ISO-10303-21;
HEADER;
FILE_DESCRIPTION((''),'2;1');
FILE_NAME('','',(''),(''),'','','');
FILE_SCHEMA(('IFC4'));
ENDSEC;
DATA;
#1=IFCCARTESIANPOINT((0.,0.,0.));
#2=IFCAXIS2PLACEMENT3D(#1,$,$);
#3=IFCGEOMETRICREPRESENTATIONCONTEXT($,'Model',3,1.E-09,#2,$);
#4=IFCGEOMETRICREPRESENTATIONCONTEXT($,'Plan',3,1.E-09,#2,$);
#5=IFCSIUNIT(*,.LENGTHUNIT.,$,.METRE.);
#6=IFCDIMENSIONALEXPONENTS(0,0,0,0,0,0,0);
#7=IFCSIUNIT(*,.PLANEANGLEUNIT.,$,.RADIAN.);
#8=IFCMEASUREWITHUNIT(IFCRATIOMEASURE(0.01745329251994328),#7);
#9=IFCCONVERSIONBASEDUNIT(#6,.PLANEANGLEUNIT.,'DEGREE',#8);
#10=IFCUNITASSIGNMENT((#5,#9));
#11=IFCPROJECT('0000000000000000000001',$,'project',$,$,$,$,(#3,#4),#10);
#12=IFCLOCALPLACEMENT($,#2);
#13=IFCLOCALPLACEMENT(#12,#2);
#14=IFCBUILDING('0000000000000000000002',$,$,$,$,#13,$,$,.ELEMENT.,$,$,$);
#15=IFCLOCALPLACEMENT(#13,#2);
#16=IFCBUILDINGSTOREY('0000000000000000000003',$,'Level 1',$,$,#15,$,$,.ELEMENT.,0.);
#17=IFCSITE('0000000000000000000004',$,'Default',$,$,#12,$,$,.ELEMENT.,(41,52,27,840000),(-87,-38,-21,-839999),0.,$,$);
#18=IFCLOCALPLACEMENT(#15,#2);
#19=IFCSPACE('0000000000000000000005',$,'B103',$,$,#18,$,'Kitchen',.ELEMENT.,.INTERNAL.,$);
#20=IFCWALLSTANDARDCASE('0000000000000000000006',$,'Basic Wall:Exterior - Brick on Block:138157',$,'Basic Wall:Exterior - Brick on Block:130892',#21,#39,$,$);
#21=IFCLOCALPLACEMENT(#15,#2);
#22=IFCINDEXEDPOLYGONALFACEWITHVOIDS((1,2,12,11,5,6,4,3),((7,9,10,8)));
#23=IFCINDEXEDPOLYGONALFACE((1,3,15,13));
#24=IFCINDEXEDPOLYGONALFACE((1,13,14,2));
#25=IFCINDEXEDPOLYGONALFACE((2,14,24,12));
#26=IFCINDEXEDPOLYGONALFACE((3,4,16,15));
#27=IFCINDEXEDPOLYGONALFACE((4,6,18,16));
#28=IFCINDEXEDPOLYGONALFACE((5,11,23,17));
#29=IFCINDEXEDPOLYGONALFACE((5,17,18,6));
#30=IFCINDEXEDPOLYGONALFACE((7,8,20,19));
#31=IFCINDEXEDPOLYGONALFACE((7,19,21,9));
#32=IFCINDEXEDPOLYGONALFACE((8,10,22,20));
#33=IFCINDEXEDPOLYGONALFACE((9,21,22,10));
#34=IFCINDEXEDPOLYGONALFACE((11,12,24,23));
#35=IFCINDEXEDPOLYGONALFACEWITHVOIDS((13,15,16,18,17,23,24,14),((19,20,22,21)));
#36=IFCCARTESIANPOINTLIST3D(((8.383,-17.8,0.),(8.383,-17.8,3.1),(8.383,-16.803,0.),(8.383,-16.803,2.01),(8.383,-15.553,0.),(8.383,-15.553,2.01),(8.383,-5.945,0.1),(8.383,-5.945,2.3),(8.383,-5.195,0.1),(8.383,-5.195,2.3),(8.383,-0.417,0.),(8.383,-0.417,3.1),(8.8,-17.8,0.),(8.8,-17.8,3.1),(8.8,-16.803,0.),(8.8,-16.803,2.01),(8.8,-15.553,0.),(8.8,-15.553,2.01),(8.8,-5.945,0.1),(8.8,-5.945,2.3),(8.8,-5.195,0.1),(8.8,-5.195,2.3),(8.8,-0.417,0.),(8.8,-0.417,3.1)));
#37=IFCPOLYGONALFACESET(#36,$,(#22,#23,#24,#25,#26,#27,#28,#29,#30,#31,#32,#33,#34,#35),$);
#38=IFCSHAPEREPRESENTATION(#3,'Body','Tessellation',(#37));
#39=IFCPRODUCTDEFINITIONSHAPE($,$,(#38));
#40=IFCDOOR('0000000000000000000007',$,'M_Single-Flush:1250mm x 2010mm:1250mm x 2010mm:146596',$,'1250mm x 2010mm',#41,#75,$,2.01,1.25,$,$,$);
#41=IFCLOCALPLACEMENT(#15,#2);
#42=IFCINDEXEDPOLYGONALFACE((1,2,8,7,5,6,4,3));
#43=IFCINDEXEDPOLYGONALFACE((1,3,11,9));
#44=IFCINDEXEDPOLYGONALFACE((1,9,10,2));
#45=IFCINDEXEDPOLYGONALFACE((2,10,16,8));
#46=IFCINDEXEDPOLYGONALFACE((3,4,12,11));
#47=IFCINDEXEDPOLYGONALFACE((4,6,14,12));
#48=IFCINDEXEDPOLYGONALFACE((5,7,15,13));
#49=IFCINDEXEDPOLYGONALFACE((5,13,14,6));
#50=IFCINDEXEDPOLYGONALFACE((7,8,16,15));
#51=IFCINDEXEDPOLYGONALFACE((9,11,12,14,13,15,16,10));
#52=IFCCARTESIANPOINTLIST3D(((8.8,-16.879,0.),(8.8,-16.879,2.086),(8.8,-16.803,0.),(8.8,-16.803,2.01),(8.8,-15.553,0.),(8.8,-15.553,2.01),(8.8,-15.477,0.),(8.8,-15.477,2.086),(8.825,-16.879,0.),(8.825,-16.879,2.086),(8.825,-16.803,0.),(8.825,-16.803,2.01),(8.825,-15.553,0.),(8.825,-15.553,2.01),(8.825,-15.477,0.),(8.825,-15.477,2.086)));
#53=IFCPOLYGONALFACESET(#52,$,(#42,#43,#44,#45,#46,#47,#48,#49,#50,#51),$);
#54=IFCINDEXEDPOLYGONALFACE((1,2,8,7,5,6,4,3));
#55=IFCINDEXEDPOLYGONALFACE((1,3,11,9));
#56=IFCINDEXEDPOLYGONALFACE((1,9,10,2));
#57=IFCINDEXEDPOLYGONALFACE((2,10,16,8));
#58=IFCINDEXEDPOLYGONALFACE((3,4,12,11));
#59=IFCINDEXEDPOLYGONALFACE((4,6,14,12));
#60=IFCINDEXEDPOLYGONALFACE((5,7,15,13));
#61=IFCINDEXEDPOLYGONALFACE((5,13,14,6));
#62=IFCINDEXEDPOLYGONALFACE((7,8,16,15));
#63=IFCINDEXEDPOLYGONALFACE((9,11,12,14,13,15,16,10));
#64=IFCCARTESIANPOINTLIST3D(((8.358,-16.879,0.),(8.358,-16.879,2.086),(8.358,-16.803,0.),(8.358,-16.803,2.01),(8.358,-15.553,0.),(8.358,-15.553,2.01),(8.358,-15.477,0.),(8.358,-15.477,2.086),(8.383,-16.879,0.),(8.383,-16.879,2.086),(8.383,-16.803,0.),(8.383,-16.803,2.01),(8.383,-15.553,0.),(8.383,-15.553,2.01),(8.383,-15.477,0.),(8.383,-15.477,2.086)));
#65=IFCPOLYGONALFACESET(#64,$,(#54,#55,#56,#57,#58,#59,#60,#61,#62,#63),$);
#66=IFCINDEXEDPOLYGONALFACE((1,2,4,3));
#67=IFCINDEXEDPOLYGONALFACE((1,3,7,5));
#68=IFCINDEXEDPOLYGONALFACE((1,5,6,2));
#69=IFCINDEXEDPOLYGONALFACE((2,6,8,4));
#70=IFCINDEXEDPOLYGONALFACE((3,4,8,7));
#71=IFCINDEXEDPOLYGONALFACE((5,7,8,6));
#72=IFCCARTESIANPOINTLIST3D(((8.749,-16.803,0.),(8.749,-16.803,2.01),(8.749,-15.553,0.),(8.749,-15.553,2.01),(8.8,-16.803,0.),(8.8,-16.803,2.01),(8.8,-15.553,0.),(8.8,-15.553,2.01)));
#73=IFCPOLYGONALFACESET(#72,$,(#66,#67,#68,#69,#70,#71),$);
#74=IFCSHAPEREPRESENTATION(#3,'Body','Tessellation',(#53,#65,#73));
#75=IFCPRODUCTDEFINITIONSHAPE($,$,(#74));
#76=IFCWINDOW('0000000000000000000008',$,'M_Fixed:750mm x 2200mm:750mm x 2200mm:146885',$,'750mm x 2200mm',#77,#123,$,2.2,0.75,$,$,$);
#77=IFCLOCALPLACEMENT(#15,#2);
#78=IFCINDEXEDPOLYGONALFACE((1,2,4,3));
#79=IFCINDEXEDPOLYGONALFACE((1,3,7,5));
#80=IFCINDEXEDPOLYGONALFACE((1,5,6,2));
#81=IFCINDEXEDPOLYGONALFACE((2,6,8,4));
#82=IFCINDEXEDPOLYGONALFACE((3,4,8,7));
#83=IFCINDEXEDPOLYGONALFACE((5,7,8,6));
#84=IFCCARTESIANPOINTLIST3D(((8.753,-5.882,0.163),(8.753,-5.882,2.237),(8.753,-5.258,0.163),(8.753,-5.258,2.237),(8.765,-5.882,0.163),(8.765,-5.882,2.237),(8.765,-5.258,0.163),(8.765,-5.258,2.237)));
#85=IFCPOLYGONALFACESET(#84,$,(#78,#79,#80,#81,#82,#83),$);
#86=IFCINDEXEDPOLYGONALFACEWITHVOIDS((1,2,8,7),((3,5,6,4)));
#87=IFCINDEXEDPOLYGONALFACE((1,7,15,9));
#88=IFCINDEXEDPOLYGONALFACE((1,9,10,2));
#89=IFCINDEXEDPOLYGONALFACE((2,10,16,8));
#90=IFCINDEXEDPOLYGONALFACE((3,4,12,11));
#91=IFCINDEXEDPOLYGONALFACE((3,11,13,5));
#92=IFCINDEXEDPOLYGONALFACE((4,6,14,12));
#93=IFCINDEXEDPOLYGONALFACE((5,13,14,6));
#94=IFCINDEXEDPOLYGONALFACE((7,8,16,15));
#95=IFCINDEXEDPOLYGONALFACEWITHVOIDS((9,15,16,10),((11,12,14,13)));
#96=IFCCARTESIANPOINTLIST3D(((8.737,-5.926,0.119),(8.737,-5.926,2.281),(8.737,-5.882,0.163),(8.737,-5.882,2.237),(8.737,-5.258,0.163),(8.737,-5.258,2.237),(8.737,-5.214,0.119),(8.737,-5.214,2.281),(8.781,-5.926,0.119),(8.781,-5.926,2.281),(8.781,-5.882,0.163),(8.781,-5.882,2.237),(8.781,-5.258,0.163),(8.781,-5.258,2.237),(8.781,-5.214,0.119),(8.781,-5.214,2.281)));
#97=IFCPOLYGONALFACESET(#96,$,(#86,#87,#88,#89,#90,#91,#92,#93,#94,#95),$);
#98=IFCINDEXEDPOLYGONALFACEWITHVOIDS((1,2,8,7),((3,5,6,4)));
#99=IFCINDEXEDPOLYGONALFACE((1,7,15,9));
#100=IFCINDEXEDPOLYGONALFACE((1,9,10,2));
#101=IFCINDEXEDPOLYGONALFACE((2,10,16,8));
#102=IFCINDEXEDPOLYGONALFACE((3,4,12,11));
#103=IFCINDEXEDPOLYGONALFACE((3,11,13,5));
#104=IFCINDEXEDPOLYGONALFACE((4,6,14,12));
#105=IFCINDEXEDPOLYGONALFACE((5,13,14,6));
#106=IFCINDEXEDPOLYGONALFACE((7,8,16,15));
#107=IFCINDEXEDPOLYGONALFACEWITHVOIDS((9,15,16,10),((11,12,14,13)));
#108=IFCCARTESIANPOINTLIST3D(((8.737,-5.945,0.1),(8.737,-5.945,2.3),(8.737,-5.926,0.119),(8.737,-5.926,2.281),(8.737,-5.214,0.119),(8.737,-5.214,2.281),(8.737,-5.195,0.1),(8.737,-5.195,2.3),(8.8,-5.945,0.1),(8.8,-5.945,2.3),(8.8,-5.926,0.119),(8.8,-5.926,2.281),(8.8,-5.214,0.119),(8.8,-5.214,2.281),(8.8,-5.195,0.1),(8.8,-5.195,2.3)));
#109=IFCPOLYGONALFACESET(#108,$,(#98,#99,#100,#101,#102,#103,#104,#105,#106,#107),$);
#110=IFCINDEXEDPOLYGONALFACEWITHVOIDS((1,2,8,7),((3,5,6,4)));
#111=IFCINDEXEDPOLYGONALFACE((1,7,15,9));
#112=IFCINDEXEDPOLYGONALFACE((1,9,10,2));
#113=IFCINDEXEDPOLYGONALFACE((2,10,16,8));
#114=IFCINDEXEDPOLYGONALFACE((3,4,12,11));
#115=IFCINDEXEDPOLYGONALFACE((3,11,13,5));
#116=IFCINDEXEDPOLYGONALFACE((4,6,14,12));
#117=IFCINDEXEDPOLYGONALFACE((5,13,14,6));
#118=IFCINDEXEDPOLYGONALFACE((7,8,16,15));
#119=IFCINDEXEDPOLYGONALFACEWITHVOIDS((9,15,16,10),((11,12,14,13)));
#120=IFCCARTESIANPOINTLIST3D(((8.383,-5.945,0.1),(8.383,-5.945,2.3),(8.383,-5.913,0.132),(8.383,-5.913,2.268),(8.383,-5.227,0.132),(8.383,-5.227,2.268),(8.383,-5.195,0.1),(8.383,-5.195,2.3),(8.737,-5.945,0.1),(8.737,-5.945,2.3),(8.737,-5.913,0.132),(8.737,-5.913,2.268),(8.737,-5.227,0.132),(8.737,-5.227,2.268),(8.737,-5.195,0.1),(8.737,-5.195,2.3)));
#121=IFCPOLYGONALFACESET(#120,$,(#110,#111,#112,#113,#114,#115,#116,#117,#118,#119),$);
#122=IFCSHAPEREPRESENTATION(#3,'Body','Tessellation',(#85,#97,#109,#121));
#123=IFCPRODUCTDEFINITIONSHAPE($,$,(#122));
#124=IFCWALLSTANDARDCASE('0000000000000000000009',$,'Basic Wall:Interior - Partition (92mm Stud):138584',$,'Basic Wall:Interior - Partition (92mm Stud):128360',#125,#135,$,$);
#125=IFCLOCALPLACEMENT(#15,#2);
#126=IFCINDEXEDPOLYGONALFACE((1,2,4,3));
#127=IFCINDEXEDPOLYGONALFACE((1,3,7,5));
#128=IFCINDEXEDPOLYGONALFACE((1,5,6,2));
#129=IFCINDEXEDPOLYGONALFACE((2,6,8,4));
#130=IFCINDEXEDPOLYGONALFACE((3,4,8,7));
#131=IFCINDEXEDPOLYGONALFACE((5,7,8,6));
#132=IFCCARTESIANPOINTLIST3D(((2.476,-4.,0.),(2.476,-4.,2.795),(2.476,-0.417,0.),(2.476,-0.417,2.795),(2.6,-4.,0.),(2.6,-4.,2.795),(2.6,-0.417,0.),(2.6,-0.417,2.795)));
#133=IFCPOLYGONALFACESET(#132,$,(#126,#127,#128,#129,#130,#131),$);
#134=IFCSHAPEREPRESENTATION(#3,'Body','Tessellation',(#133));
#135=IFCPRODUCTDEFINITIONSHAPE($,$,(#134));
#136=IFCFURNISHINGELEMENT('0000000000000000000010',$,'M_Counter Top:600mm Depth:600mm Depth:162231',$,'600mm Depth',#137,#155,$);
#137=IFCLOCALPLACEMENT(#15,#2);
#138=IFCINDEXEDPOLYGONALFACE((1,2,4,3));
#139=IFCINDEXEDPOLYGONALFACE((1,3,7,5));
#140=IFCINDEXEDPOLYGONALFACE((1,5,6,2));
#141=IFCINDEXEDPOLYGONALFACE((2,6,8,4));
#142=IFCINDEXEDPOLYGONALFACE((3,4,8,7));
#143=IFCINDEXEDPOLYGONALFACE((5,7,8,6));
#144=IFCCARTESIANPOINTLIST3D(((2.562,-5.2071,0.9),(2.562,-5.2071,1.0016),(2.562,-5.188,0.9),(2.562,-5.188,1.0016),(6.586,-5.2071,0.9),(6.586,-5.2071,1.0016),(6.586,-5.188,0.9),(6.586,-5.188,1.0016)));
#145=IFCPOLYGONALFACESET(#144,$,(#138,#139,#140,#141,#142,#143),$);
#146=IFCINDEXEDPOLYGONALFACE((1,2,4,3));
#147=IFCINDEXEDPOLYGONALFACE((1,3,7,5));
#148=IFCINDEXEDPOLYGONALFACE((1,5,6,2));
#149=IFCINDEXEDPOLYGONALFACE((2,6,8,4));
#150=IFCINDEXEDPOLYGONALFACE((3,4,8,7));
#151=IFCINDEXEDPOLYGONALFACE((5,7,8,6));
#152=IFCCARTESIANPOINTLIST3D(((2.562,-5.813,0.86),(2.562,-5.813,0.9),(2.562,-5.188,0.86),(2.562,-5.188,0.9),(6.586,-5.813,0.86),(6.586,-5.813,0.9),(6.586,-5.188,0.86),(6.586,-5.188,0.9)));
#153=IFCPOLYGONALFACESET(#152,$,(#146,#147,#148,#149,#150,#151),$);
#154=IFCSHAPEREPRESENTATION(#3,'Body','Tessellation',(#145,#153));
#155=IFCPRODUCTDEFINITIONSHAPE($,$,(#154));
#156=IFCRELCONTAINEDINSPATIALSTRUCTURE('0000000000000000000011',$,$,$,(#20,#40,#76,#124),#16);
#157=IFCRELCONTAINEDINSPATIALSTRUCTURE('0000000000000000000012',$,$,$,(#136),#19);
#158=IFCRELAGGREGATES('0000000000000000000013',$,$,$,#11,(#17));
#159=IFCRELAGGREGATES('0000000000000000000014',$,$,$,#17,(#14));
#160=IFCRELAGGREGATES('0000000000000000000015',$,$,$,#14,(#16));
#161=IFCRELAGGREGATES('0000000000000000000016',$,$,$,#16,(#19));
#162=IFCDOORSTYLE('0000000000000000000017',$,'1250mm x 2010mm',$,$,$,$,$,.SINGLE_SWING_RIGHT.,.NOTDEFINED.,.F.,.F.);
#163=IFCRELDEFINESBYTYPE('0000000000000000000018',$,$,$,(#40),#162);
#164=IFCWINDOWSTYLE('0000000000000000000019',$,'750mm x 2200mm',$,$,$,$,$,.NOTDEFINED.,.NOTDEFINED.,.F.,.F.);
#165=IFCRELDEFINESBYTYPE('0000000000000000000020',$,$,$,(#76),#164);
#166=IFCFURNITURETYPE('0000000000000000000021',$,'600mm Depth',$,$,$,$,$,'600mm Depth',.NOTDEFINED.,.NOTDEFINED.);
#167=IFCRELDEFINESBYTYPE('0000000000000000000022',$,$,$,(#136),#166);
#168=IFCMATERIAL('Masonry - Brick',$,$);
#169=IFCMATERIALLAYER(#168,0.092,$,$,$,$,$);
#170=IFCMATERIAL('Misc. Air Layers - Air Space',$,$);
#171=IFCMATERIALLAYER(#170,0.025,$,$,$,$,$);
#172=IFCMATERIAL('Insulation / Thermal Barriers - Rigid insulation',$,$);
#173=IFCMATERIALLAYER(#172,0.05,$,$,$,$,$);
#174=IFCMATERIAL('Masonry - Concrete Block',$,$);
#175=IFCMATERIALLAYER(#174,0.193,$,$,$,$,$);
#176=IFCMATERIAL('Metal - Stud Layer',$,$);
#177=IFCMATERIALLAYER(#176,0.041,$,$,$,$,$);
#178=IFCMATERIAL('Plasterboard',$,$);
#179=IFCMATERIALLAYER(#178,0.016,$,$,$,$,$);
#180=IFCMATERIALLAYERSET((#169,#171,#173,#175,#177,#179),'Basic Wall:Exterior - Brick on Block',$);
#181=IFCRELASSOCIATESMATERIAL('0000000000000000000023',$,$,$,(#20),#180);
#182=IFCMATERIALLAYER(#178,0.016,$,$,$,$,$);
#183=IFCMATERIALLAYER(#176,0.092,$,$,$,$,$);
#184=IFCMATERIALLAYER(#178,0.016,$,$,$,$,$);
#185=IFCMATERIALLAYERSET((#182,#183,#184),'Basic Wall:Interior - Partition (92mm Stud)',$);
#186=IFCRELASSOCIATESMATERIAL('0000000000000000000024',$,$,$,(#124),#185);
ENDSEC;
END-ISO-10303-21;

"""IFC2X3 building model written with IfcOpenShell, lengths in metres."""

from ifc_helpers import new_model, entity, si_unit, converted_unit, frame, frame_2d, origin, origin_2d_with_axis, place, context, project, spatial, polyline, rectangle, outline, extrude, source, transform, mapped, material, layer, layer_set, layer_usage, type_object, type_shapes, element, fill, save


model = new_model("IFC2X3")

# Units and contexts
model_context = context("Model", 3, precision=1e-09, world=origin())
plan_context = context("Plan", 3, precision=1e-09, world=origin())
ifc_project = project(units=[si_unit("LENGTHUNIT", "METRE"), converted_unit("PLANEANGLEUNIT", "DEGREE", entity("IfcRatioMeasure", 0.01745329251994328), si_unit("PLANEANGLEUNIT", "RADIAN"), dimensions=[0, 0, 0, 0, 0, 0, 0])], contexts=[model_context, plan_context])

# Site, building, storey
site_placement = place(None, origin())
site = spatial("IfcSite", under=ifc_project, at=site_placement, Name="Default", CompositionType="ELEMENT", RefLatitude=(41, 52, 27, 840000), RefLongitude=(-87, -38, -21, -839999), RefElevation=0.0)
building_placement = place(site_placement, origin())
building = spatial("IfcBuilding", under=site, at=building_placement, CompositionType="ELEMENT")
storey_placement = place(building_placement, origin())
storey = spatial("IfcBuildingStorey", under=building, at=storey_placement, Name="Level 1", CompositionType="ELEMENT", Elevation=0.0)

# Wall, openings, door, window
ifc_material_1 = material(Name="Masonry - Brick")
ifc_layer_1 = layer(ifc_material_1, 0.092)
ifc_material_2 = material(Name="Misc. Air Layers - Air Space")
ifc_layer_2 = layer(ifc_material_2, 0.025)
ifc_material_3 = material(Name="Insulation / Thermal Barriers - Rigid insulation")
ifc_layer_3 = layer(ifc_material_3, 0.05)
ifc_material_4 = material(Name="Masonry - Concrete Block")
ifc_layer_4 = layer(ifc_material_4, 0.193)
ifc_material_5 = material(Name="Metal - Stud Layer")
ifc_layer_5 = layer(ifc_material_5, 0.041)
ifc_material_6 = material(Name="Plasterboard")
ifc_layer_6 = layer(ifc_material_6, 0.016)
ifc_layer_set_1 = layer_set([ifc_layer_1, ifc_layer_2, ifc_layer_3, ifc_layer_4, ifc_layer_5, ifc_layer_6], Name="Basic Wall:Exterior - Brick on Block")
ifc_layer_usage_1 = layer_usage(ifc_layer_set_1, "AXIS2", "NEGATIVE", 0.2085)
wall_1_placement = place(storey_placement, frame((8.5915, -0.417, 0.0), z_axis=(0.0, 0.0, 1.0), x_axis=(0.0, -1.0, 0.0)))
wall_1 = element("IfcWallStandardCase", 1, at=wall_1_placement, inside=storey, material=ifc_layer_usage_1, Name="Basic Wall:Exterior - Brick on Block:138157", ObjectType="Basic Wall:Exterior - Brick on Block:130892", context=model_context, shape_type="SweptSolid", body=[
    extrude(rectangle(XDim=17.383, YDim=0.417, at=frame_2d((8.6915, 0.0), x_axis=(-1.0, 0.0))), origin(), (0.0, 0.0, 1.0), 3.1),
])
opening_1_placement = place(wall_1_placement, frame((15.136, -0.2085, 0.0)))
opening_1 = element("IfcOpeningElement", 2, at=opening_1_placement, cuts=wall_1, ObjectType="Opening", context=model_context, shape_type="SweptSolid", body=[
    extrude(rectangle(XDim=1.25, YDim=2.01, at=frame_2d((1.005, 0.625), x_axis=(0.0, 1.0))), frame((0.0, 0.0, 0.0), z_axis=(0.0, 1.0, 0.0), x_axis=(0.0, 0.0, 1.0)), (0.0, 0.0, 1.0), 0.417),
])
opening_2_placement = place(wall_1_placement, frame((4.778, -0.2085, 0.1)))
opening_2 = element("IfcOpeningElement", 3, at=opening_2_placement, cuts=wall_1, ObjectType="Opening", context=model_context, shape_type="SweptSolid", body=[
    extrude(rectangle(XDim=2.2, YDim=0.75, at=frame_2d((1.1, 0.375), x_axis=(1.0, 0.0))), frame((0.0, 0.0, 0.0), z_axis=(0.0, 1.0, 0.0), x_axis=(0.0, 0.0, 1.0)), (0.0, 0.0, 1.0), 0.417),
])
door_style = type_object("IfcDoorStyle", Name="1250mm x 2010mm", ConstructionType="NOTDEFINED", OperationType="SINGLE_SWING_RIGHT", ParameterTakesPrecedence=False, Sizeable=False)
shared_shape_1 = source(origin(), model_context, "Body", "SweptSolid", [
    extrude(outline(polyline([(-0.701, -1.062), (0.701, -1.062), (0.701, 1.024), (0.625, 1.024), (0.625, -0.986), (-0.625, -0.986), (-0.625, 1.024), (-0.701, 1.024), (-0.701, -1.062)])), frame((0.625, 0.417, 1.024), z_axis=(0.0, 1.0, 0.0), x_axis=(1.0, 0.0, 0.0)), (0.0, 0.0, 1.0), 0.025),
    extrude(outline(polyline([(-1.062, -0.701), (1.024, -0.701), (1.024, -0.625), (-0.986, -0.625), (-0.986, 0.625), (1.024, 0.625), (1.024, 0.701), (-1.062, 0.701), (-1.062, -0.701)])), frame((0.625, -0.025, 1.024), z_axis=(0.0, 1.0, 0.0), x_axis=(0.0, 0.0, -1.0)), (0.0, 0.0, 1.0), 0.025),
    extrude(rectangle(XDim=0.051, YDim=1.25, at=origin_2d_with_axis()), frame((0.625, 0.3915, 0.0), z_axis=(0.0, 0.0, 1.0), x_axis=(0.0, 1.0, 0.0)), (0.0, 0.0, 1.0), 2.01),
])
type_shapes(door_style, [shared_shape_1])
door_placement = place(opening_1_placement, origin())
door = element("IfcDoor", 4, at=door_placement, inside=storey, type_object=door_style, Name="M_Single-Flush:1250mm x 2010mm:1250mm x 2010mm:146596", ObjectType="1250mm x 2010mm", OverallHeight=2.01, OverallWidth=1.25, context=model_context, shape_type="MappedRepresentation", body=[
    mapped(shared_shape_1, transform((0.0, 0.0, 0.0), scale=1.0)),
])
fill(opening_1, door)
window_style = type_object("IfcWindowStyle", Name="750mm x 2200mm", ConstructionType="NOTDEFINED", OperationType="NOTDEFINED", ParameterTakesPrecedence=False, Sizeable=False)
shared_shape_2 = source(origin(), model_context, "Body", "SweptSolid", [
    extrude(rectangle(XDim=0.012, YDim=0.624, at=origin_2d_with_axis()), frame((0.375, 0.376, 0.063), z_axis=(0.0, 0.0, 1.0), x_axis=(0.0, -1.0, 0.0)), (0.0, 0.0, 1.0), 2.074),
    extrude(outline(polyline([(-0.356, -1.081), (0.356, -1.081), (0.356, 1.081), (-0.356, 1.081), (-0.356, -1.081)]), holes=[polyline([(-0.312, -1.037), (-0.312, 1.037), (0.312, 1.037), (0.312, -1.037), (-0.312, -1.037)])]), frame((0.375, 0.354, 1.1), z_axis=(0.0, 1.0, 0.0), x_axis=(1.0, 0.0, 0.0)), (0.0, 0.0, 1.0), 0.044),
    extrude(outline(polyline([(-0.375, -1.1), (0.375, -1.1), (0.375, 1.1), (-0.375, 1.1), (-0.375, -1.1)]), holes=[polyline([(-0.356, -1.081), (-0.356, 1.081), (0.356, 1.081), (0.356, -1.081), (-0.356, -1.081)])]), frame((0.375, 0.354, 1.1), z_axis=(0.0, 1.0, 0.0), x_axis=(1.0, 0.0, 0.0)), (0.0, 0.0, 1.0), 0.063),
    extrude(outline(polyline([(-0.375, -1.1), (0.375, -1.1), (0.375, 1.1), (-0.375, 1.1), (-0.375, -1.1)]), holes=[polyline([(-0.343, -1.068), (-0.343, 1.068), (0.343, 1.068), (0.343, -1.068), (-0.343, -1.068)])]), frame((0.375, 0.0, 1.1), z_axis=(0.0, 1.0, 0.0), x_axis=(1.0, 0.0, 0.0)), (0.0, 0.0, 1.0), 0.354),
])
type_shapes(window_style, [shared_shape_2])
window_placement = place(opening_2_placement, origin())
window = element("IfcWindow", 5, at=window_placement, inside=storey, type_object=window_style, Name="M_Fixed:750mm x 2200mm:750mm x 2200mm:146885", ObjectType="750mm x 2200mm", OverallHeight=2.2, OverallWidth=0.75, context=model_context, shape_type="MappedRepresentation", body=[
    mapped(shared_shape_2, transform((0.0, 0.0, 0.0), scale=1.0)),
])
fill(opening_2, window)

# Wall
ifc_layer_7 = layer(ifc_material_6, 0.016)
ifc_layer_8 = layer(ifc_material_5, 0.092)
ifc_layer_9 = layer(ifc_material_6, 0.016)
ifc_layer_set_2 = layer_set([ifc_layer_7, ifc_layer_8, ifc_layer_9], Name="Basic Wall:Interior - Partition (92mm Stud)")
ifc_layer_usage_2 = layer_usage(ifc_layer_set_2, "AXIS2", "NEGATIVE", 0.062)
wall_2_placement = place(storey_placement, frame((2.538, -0.417, 0.0), z_axis=(0.0, 0.0, 1.0), x_axis=(0.0, -1.0, 0.0)))
element("IfcWallStandardCase", 6, at=wall_2_placement, inside=storey, material=ifc_layer_usage_2, Name="Basic Wall:Interior - Partition (92mm Stud):138584", ObjectType="Basic Wall:Interior - Partition (92mm Stud):128360", context=model_context, shape_type="SweptSolid", body=[
    extrude(rectangle(XDim=3.583, YDim=0.124, at=frame_2d((1.7915, 0.0), x_axis=(-1.0, 0.0))), origin(), (0.0, 0.0, 1.0), 2.795),
])

# Shared definitions
space_1_placement = place(storey_placement, origin())
space_1 = spatial("IfcSpace", under=storey, at=space_1_placement, Name="B103", LongName="Kitchen", CompositionType="ELEMENT", InteriorOrExteriorSpace="INTERNAL")

# Furnishing element
furniture_type_1 = type_object("IfcFurnitureType", Name="600mm Depth", ElementType="600mm Depth", AssemblyPlace="NOTDEFINED")
shared_shape_3 = source(origin(), model_context, "Body", "SweptSolid", [
    extrude(rectangle(XDim=0.0191, YDim=4.024, at=origin_2d_with_axis()), frame((0.8115, -0.0095, 0.9), z_axis=(0.0, 0.0, 1.0), x_axis=(0.0, -1.0, 0.0)), (0.0, 0.0, 1.0), 0.1016),
    extrude(rectangle(XDim=4.024, YDim=0.625, at=origin_2d_with_axis()), frame((0.8115, -0.3125, 0.86), z_axis=(0.0, 0.0, 1.0), x_axis=(-1.0, 0.0, 0.0)), (0.0, 0.0, 1.0), 0.04),
])
type_shapes(furniture_type_1, [shared_shape_3])
furnishing_1_placement = place(space_1_placement, frame((3.7625, -5.188, 0.0)))
element("IfcFurnishingElement", 7, at=furnishing_1_placement, inside=space_1, type_object=furniture_type_1, Name="M_Counter Top:600mm Depth:600mm Depth:162231", ObjectType="600mm Depth", context=model_context, shape_type="MappedRepresentation", body=[
    mapped(shared_shape_3, transform((0.0, 0.0, 0.0), scale=1.0)),
])

save(model, "model.ifc")
